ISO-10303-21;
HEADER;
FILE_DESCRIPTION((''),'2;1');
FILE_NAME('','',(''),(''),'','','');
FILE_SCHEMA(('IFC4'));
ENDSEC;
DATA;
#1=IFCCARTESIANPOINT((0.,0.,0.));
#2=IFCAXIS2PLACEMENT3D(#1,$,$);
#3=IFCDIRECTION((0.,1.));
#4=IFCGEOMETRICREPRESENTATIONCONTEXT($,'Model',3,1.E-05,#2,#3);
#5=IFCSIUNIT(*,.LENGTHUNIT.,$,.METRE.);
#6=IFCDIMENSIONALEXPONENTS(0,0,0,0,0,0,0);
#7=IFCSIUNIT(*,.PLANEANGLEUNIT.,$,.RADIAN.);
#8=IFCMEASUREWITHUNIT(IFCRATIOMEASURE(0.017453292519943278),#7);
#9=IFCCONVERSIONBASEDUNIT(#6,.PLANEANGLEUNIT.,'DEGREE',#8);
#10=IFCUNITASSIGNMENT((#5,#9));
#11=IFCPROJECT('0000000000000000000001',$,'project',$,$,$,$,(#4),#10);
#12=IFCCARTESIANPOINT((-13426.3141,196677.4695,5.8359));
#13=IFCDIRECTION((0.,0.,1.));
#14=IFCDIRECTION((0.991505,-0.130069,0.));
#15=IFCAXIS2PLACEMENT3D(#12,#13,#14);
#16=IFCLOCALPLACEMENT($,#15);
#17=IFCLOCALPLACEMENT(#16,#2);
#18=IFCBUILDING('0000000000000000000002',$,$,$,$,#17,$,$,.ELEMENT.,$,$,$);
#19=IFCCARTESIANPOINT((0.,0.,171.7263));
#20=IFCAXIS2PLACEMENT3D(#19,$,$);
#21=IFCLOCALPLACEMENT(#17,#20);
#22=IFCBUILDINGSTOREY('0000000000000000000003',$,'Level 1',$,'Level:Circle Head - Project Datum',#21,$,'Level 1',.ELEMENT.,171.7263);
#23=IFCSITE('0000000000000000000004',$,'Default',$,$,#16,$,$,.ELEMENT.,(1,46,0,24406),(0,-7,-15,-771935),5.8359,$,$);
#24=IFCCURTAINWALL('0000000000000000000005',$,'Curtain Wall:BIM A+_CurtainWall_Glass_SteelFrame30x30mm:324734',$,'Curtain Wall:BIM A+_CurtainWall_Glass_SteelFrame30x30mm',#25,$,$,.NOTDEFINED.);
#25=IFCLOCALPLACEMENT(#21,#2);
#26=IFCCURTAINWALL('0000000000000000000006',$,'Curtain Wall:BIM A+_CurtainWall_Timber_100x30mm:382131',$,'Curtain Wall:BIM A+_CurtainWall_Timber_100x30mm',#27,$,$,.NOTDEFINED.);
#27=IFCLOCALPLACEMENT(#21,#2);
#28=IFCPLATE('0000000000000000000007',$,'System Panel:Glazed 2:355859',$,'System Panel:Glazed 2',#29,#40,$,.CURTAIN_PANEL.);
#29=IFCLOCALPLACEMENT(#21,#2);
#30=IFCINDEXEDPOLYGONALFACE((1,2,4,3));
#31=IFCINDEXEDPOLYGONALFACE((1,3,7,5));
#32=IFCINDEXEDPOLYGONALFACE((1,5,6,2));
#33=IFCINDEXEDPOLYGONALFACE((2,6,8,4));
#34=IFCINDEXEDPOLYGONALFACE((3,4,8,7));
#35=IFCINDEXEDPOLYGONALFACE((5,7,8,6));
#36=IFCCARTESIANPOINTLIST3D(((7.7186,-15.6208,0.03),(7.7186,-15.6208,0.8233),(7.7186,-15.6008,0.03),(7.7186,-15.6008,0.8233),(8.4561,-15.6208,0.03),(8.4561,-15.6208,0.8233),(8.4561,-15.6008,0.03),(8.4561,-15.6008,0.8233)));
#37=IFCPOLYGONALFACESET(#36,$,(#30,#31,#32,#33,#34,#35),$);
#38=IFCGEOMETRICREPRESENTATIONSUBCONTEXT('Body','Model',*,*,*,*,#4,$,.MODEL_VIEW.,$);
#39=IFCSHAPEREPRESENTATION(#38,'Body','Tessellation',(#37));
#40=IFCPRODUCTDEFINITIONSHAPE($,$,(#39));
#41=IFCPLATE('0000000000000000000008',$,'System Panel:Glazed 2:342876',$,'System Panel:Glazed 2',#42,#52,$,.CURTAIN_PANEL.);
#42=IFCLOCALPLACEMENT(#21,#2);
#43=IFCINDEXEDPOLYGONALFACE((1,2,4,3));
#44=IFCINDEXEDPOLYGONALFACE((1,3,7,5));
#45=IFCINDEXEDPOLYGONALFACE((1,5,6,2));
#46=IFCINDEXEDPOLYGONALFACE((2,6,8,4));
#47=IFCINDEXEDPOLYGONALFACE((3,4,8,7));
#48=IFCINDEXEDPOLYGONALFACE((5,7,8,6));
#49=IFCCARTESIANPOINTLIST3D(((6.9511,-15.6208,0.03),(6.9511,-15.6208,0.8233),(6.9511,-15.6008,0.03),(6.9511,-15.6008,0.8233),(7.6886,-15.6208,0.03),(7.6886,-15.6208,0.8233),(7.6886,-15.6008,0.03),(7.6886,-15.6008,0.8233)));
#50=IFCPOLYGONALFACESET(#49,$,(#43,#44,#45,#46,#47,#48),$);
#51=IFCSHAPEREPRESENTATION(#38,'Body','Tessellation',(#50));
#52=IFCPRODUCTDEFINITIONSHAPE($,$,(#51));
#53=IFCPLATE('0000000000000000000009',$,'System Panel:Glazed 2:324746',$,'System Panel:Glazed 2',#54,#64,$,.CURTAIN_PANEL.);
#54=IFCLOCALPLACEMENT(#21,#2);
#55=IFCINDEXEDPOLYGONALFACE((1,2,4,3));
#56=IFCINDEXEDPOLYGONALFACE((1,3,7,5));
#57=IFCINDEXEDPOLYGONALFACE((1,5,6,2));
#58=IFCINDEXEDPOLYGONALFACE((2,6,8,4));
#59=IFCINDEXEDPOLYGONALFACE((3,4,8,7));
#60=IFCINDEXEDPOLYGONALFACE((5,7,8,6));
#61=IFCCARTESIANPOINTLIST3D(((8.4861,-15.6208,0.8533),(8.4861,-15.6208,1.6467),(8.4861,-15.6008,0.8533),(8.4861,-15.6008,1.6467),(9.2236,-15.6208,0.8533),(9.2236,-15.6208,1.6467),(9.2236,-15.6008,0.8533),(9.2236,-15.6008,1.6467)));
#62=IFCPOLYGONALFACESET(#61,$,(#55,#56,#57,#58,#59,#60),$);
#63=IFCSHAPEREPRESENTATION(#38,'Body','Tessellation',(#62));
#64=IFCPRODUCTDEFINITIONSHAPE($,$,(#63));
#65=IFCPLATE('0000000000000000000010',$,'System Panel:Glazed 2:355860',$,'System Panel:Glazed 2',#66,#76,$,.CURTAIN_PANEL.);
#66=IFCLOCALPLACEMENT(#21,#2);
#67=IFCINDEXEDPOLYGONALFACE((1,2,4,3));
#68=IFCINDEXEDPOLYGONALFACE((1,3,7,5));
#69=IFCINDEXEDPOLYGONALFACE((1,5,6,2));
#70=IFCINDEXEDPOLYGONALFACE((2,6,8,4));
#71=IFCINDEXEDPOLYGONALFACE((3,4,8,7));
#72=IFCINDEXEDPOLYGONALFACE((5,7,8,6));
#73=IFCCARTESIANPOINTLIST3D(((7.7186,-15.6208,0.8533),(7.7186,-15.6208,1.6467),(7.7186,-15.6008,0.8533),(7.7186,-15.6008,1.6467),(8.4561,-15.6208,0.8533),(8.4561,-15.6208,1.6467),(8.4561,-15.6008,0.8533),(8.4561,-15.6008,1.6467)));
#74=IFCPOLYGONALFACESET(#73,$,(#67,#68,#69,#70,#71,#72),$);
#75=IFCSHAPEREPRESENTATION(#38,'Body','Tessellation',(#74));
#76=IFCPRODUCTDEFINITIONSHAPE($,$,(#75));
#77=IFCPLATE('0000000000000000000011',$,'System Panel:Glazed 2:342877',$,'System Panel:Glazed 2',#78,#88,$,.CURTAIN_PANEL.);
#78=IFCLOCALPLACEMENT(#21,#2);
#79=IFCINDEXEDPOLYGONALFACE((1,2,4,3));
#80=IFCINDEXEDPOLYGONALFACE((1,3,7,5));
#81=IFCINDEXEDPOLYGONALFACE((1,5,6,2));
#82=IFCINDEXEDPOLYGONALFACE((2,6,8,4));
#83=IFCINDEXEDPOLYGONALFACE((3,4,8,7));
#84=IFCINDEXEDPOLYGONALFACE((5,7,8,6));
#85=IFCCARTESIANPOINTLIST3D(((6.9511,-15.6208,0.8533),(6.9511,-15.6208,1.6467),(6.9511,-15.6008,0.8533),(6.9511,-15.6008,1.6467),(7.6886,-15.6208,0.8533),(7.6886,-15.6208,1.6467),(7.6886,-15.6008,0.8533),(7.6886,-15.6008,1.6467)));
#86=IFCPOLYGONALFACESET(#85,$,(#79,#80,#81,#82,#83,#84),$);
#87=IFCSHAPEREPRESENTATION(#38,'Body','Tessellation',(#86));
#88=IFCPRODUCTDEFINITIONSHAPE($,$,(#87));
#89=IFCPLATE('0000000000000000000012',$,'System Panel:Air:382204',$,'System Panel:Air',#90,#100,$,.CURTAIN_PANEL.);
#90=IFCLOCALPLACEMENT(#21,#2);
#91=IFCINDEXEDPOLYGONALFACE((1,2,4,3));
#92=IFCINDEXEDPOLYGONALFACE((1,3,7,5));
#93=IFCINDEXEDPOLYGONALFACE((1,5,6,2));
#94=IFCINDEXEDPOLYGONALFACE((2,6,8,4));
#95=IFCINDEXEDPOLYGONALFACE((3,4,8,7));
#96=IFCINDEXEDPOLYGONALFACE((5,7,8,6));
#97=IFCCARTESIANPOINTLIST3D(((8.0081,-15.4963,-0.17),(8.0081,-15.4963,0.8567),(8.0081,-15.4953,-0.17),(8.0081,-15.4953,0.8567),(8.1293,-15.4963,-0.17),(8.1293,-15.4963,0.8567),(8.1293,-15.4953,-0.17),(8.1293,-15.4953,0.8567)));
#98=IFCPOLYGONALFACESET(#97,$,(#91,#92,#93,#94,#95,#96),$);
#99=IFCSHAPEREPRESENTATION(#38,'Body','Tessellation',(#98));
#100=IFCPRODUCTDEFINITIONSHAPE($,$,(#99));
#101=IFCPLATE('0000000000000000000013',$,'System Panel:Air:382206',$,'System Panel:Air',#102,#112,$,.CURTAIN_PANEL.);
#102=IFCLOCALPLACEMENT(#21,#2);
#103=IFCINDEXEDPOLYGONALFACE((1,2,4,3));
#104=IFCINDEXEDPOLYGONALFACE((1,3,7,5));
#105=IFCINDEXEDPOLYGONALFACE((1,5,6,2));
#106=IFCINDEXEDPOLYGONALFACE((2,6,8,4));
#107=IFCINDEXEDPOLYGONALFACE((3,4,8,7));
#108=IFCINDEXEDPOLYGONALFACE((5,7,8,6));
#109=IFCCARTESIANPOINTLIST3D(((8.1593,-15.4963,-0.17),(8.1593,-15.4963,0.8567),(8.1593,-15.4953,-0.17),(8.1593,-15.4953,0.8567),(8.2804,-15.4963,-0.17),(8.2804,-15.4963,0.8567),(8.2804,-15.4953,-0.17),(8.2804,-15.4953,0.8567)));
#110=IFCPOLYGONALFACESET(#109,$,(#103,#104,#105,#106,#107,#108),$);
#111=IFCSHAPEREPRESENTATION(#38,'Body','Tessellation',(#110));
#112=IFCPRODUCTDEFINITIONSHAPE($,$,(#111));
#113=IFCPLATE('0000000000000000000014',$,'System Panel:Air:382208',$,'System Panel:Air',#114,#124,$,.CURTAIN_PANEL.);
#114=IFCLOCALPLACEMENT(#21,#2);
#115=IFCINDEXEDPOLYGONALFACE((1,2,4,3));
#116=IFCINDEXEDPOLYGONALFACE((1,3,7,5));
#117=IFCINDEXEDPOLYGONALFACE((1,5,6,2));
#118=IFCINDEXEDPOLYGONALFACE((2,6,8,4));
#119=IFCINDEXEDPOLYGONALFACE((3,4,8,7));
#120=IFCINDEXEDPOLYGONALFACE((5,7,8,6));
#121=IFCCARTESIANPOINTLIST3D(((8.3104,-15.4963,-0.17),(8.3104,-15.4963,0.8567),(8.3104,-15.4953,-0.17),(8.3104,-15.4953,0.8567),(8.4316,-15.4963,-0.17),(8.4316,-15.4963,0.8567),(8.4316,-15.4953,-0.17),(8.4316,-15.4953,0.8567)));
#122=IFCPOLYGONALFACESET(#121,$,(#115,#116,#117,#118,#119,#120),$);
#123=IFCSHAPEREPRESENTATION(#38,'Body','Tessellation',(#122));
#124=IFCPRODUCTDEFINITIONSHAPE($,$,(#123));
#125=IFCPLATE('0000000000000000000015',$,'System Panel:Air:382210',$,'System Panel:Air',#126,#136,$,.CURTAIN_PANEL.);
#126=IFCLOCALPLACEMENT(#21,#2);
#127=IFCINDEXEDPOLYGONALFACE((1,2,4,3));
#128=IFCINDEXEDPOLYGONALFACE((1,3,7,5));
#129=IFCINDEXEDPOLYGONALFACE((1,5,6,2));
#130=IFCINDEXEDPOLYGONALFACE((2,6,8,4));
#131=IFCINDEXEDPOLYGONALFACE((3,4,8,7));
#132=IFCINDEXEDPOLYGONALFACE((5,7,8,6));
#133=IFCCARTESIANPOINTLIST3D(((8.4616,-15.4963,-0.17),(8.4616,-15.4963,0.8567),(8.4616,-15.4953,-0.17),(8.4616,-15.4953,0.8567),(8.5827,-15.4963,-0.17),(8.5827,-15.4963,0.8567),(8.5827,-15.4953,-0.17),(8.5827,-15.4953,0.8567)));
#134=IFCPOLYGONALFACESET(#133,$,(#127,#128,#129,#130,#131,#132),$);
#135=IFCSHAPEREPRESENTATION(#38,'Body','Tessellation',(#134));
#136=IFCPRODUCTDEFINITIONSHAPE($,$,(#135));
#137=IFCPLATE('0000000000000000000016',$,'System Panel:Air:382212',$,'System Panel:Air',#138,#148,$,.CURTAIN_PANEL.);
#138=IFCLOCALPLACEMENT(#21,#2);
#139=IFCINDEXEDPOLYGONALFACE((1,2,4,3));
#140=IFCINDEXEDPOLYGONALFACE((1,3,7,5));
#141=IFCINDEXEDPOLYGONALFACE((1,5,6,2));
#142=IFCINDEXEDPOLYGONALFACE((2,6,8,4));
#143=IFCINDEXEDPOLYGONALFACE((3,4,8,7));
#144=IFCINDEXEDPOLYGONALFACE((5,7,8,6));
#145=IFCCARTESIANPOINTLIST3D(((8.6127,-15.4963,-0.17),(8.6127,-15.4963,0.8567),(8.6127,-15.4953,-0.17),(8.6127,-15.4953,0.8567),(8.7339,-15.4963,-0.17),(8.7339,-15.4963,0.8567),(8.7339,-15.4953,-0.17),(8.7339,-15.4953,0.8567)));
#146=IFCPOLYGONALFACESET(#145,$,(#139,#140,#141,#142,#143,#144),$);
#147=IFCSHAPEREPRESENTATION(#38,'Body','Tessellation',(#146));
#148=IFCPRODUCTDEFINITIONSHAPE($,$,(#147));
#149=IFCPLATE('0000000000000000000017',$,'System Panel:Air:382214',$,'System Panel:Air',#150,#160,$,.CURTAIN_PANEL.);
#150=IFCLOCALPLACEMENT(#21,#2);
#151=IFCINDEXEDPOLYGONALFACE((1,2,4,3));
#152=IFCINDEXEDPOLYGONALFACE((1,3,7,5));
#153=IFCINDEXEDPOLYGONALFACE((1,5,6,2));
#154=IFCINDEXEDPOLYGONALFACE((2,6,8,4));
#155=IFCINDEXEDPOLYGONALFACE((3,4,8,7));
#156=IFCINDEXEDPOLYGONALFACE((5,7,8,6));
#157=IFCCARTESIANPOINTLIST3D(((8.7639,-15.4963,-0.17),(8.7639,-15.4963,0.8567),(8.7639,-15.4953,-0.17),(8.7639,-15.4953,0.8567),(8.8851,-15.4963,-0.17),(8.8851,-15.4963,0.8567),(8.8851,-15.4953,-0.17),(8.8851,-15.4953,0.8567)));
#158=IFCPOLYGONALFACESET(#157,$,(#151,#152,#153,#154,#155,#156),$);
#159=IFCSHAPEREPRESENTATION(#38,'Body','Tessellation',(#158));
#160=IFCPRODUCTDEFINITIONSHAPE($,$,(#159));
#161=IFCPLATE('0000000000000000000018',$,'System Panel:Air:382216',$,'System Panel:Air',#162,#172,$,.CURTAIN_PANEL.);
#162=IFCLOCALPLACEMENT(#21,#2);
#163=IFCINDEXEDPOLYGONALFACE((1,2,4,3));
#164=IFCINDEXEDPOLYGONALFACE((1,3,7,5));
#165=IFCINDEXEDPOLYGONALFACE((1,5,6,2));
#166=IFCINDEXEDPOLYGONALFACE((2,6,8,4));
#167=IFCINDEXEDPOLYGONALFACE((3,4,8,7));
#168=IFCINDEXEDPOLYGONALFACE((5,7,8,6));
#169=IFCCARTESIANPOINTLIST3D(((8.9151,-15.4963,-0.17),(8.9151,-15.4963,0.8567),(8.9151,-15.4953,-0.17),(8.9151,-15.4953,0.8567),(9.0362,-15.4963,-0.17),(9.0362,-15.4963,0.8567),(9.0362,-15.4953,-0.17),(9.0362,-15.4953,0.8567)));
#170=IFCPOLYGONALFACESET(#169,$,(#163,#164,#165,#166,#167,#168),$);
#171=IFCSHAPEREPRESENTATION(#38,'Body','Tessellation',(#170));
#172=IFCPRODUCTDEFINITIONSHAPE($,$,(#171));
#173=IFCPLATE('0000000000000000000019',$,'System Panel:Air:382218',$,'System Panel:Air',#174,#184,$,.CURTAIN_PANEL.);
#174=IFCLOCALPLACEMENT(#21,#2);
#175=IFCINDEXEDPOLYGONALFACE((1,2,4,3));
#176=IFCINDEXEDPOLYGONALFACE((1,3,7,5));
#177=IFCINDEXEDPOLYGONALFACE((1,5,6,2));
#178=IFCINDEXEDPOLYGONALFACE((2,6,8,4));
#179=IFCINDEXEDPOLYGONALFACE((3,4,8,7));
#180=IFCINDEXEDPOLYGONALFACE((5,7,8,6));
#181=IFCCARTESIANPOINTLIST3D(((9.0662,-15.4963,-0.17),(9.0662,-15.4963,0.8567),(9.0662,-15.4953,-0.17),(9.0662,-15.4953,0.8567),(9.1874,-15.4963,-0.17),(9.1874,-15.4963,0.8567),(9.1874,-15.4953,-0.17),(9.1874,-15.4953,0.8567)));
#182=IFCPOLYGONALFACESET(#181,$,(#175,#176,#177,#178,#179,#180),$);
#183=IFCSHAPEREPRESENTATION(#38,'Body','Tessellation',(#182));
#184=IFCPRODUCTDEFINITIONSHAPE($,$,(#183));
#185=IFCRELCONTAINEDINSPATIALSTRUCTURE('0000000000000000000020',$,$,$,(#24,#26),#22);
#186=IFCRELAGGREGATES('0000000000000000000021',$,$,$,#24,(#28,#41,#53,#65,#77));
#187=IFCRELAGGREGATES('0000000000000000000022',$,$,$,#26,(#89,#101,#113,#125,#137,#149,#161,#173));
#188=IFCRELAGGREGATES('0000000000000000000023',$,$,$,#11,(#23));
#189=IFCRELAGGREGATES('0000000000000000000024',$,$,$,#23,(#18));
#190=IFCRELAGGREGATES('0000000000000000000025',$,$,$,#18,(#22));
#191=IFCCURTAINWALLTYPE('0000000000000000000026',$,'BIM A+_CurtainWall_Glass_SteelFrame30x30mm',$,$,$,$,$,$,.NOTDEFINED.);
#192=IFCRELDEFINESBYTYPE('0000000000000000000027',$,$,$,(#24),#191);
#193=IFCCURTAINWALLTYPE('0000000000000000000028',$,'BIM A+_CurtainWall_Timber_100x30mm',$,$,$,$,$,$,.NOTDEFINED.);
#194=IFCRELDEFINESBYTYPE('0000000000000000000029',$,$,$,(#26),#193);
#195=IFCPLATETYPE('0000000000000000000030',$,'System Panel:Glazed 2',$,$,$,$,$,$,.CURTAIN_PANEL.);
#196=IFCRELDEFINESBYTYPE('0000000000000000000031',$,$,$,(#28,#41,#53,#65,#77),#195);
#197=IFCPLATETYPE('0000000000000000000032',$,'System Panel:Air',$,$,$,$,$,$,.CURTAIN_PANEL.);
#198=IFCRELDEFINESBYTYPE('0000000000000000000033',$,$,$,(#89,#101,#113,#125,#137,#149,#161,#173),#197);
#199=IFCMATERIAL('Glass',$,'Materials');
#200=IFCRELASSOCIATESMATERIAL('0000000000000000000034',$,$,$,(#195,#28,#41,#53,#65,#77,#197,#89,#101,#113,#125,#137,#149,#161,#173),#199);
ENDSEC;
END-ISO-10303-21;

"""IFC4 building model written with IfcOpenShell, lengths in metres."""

from ifc_helpers import new_model, entity, si_unit, converted_unit, direction, frame, origin, place, context, subcontext, project, spatial, indexed_curve, outline, extrude, source, transform, mapped, material, type_object, type_shapes, element, aggregate, save


model = new_model("IFC4")

# Units and contexts
model_context = context("Model", 3, precision=1e-05, world=origin(), true_north=direction((0.0, 1.0)))
body_context = subcontext(model_context, "Body", "Model", "MODEL_VIEW")
ifc_project = project(units=[si_unit("LENGTHUNIT", "METRE"), converted_unit("PLANEANGLEUNIT", "DEGREE", entity("IfcRatioMeasure", 0.017453292519943278), si_unit("PLANEANGLEUNIT", "RADIAN"), dimensions=[0, 0, 0, 0, 0, 0, 0])], contexts=[model_context])

# Site, building, storey
site_placement = place(None, frame((-13426.3141, 196677.4695, 5.8359), z_axis=(0.0, 0.0, 1.0), x_axis=(0.991505, -0.130069, 0.0)))
site = spatial("IfcSite", under=ifc_project, at=site_placement, Name="Default", CompositionType="ELEMENT", RefLatitude=(1, 46, 0, 24406), RefLongitude=(0, -7, -15, -771935), RefElevation=5.8359)
building_placement = place(site_placement, origin())
building = spatial("IfcBuilding", under=site, at=building_placement, CompositionType="ELEMENT")
storey_placement = place(building_placement, frame((0.0, 0.0, 171.7263)))
storey = spatial("IfcBuildingStorey", under=building, at=storey_placement, Name="Level 1", ObjectType="Level:Circle Head - Project Datum", LongName="Level 1", CompositionType="ELEMENT", Elevation=171.7263)

# Curtain walls
curtain_wall_type_1 = type_object("IfcCurtainWallType", Name="BIM A+_CurtainWall_Glass_SteelFrame30x30mm", PredefinedType="NOTDEFINED")
curtain_wall_1_placement = place(storey_placement, frame((0.0, 0.0, -171.7263)))
curtain_wall_1 = element("IfcCurtainWall", 1, at=curtain_wall_1_placement, inside=storey, type_object=curtain_wall_type_1, Name="Curtain Wall:BIM A+_CurtainWall_Glass_SteelFrame30x30mm:324734", ObjectType="Curtain Wall:BIM A+_CurtainWall_Glass_SteelFrame30x30mm", PredefinedType="NOTDEFINED")
curtain_wall_type_2 = type_object("IfcCurtainWallType", Name="BIM A+_CurtainWall_Timber_100x30mm", PredefinedType="NOTDEFINED")
curtain_wall_2_placement = place(storey_placement, frame((0.0, 0.0, -171.7263)))
curtain_wall_2 = element("IfcCurtainWall", 2, at=curtain_wall_2_placement, inside=storey, type_object=curtain_wall_type_2, Name="Curtain Wall:BIM A+_CurtainWall_Timber_100x30mm:382131", ObjectType="Curtain Wall:BIM A+_CurtainWall_Timber_100x30mm", PredefinedType="NOTDEFINED")

# Plates
ifc_material_1 = material(Name="Glass", Category="Materials")
plate_type_1 = type_object("IfcPlateType", Name="System Panel:Glazed 2", PredefinedType="CURTAIN_PANEL", material=ifc_material_1)
shared_shape_1 = source(origin(), body_context, "Body", "SweptSolid", [
    extrude(outline(indexed_curve([(-0.01, -0.3688), (0.01, -0.3688), (0.01, 0.3688), (-0.01, 0.3688), (-0.01, -0.3688)], self_intersect=False)), frame((0.0, 0.0, 0.0), z_axis=(0.0, 0.0, 1.0), x_axis=(0.0, 1.0, 0.0)), (0.0, 0.0, 1.0), 0.7933),
])
type_shapes(plate_type_1, [shared_shape_1])
plate_1_placement = place(curtain_wall_1_placement, frame((8.0873, -15.6108, 171.7563), z_axis=(0.0, 0.0, 1.0), x_axis=(-1.0, 0.0, 0.0)))
plate_1 = element("IfcPlate", 3, at=plate_1_placement, type_object=plate_type_1, material=ifc_material_1, Name="System Panel:Glazed 2:355859", ObjectType="System Panel:Glazed 2", PredefinedType="CURTAIN_PANEL", context=body_context, shape_type="MappedRepresentation", body=[
    mapped(shared_shape_1, transform((0.0, 0.0, 0.0), scale=1.0)),
])
plate_2_placement = place(curtain_wall_1_placement, frame((7.3198, -15.6108, 171.7563), z_axis=(0.0, 0.0, 1.0), x_axis=(-1.0, 0.0, 0.0)))
plate_2 = element("IfcPlate", 4, at=plate_2_placement, type_object=plate_type_1, material=ifc_material_1, Name="System Panel:Glazed 2:342876", ObjectType="System Panel:Glazed 2", PredefinedType="CURTAIN_PANEL", context=body_context, shape_type="MappedRepresentation", body=[
    mapped(shared_shape_1, transform((0.0, 0.0, 0.0), scale=1.0)),
])
plate_3_placement = place(curtain_wall_1_placement, frame((8.8548, -15.6108, 172.5796), z_axis=(0.0, 0.0, 1.0), x_axis=(-1.0, 0.0, 0.0)))
plate_3 = element("IfcPlate", 5, at=plate_3_placement, type_object=plate_type_1, material=ifc_material_1, Name="System Panel:Glazed 2:324746", ObjectType="System Panel:Glazed 2", PredefinedType="CURTAIN_PANEL", context=body_context, shape_type="MappedRepresentation", body=[
    mapped(shared_shape_1, transform((0.0, 0.0, 0.0), scale=1.0)),
])
plate_4_placement = place(curtain_wall_1_placement, frame((8.0873, -15.6108, 172.5796), z_axis=(0.0, 0.0, 1.0), x_axis=(-1.0, 0.0, 0.0)))
plate_4 = element("IfcPlate", 6, at=plate_4_placement, type_object=plate_type_1, material=ifc_material_1, Name="System Panel:Glazed 2:355860", ObjectType="System Panel:Glazed 2", PredefinedType="CURTAIN_PANEL", context=body_context, shape_type="MappedRepresentation", body=[
    mapped(shared_shape_1, transform((0.0, 0.0, 0.0), scale=1.0)),
])
plate_5_placement = place(curtain_wall_1_placement, frame((7.3198, -15.6108, 172.5796), z_axis=(0.0, 0.0, 1.0), x_axis=(-1.0, 0.0, 0.0)))
plate_5 = element("IfcPlate", 7, at=plate_5_placement, type_object=plate_type_1, material=ifc_material_1, Name="System Panel:Glazed 2:342877", ObjectType="System Panel:Glazed 2", PredefinedType="CURTAIN_PANEL", context=body_context, shape_type="MappedRepresentation", body=[
    mapped(shared_shape_1, transform((0.0, 0.0, 0.0), scale=1.0)),
])
aggregate(curtain_wall_1, [plate_1, plate_2, plate_3, plate_4, plate_5])
plate_type_2 = type_object("IfcPlateType", Name="System Panel:Air", PredefinedType="CURTAIN_PANEL", material=ifc_material_1)
shared_shape_2 = source(origin(), body_context, "Body", "SweptSolid", [
    extrude(outline(indexed_curve([(-0.0005, -0.0606), (0.0005, -0.0606), (0.0005, 0.0606), (-0.0005, 0.0606), (-0.0005, -0.0606)], self_intersect=False)), frame((0.0, 0.0, 0.0), z_axis=(0.0, 0.0, 1.0), x_axis=(0.0, 1.0, 0.0)), (0.0, 0.0, 1.0), 1.0267),
])
type_shapes(plate_type_2, [shared_shape_2])
plate_6_placement = place(curtain_wall_2_placement, frame((8.0687, -15.4958, 171.5563)))
plate_6 = element("IfcPlate", 8, at=plate_6_placement, type_object=plate_type_2, material=ifc_material_1, Name="System Panel:Air:382204", ObjectType="System Panel:Air", PredefinedType="CURTAIN_PANEL", context=body_context, shape_type="MappedRepresentation", body=[
    mapped(shared_shape_2, transform((0.0, 0.0, 0.0), scale=1.0)),
])
plate_7_placement = place(curtain_wall_2_placement, frame((8.2198, -15.4958, 171.5563)))
plate_7 = element("IfcPlate", 9, at=plate_7_placement, type_object=plate_type_2, material=ifc_material_1, Name="System Panel:Air:382206", ObjectType="System Panel:Air", PredefinedType="CURTAIN_PANEL", context=body_context, shape_type="MappedRepresentation", body=[
    mapped(shared_shape_2, transform((0.0, 0.0, 0.0), scale=1.0)),
])
plate_8_placement = place(curtain_wall_2_placement, frame((8.371, -15.4958, 171.5563)))
plate_8 = element("IfcPlate", 10, at=plate_8_placement, type_object=plate_type_2, material=ifc_material_1, Name="System Panel:Air:382208", ObjectType="System Panel:Air", PredefinedType="CURTAIN_PANEL", context=body_context, shape_type="MappedRepresentation", body=[
    mapped(shared_shape_2, transform((0.0, 0.0, 0.0), scale=1.0)),
])
plate_9_placement = place(curtain_wall_2_placement, frame((8.5222, -15.4958, 171.5563)))
plate_9 = element("IfcPlate", 11, at=plate_9_placement, type_object=plate_type_2, material=ifc_material_1, Name="System Panel:Air:382210", ObjectType="System Panel:Air", PredefinedType="CURTAIN_PANEL", context=body_context, shape_type="MappedRepresentation", body=[
    mapped(shared_shape_2, transform((0.0, 0.0, 0.0), scale=1.0)),
])
plate_10_placement = place(curtain_wall_2_placement, frame((8.6733, -15.4958, 171.5563)))
plate_10 = element("IfcPlate", 12, at=plate_10_placement, type_object=plate_type_2, material=ifc_material_1, Name="System Panel:Air:382212", ObjectType="System Panel:Air", PredefinedType="CURTAIN_PANEL", context=body_context, shape_type="MappedRepresentation", body=[
    mapped(shared_shape_2, transform((0.0, 0.0, 0.0), scale=1.0)),
])
plate_11_placement = place(curtain_wall_2_placement, frame((8.8245, -15.4958, 171.5563)))
plate_11 = element("IfcPlate", 13, at=plate_11_placement, type_object=plate_type_2, material=ifc_material_1, Name="System Panel:Air:382214", ObjectType="System Panel:Air", PredefinedType="CURTAIN_PANEL", context=body_context, shape_type="MappedRepresentation", body=[
    mapped(shared_shape_2, transform((0.0, 0.0, 0.0), scale=1.0)),
])
plate_12_placement = place(curtain_wall_2_placement, frame((8.9757, -15.4958, 171.5563)))
plate_12 = element("IfcPlate", 14, at=plate_12_placement, type_object=plate_type_2, material=ifc_material_1, Name="System Panel:Air:382216", ObjectType="System Panel:Air", PredefinedType="CURTAIN_PANEL", context=body_context, shape_type="MappedRepresentation", body=[
    mapped(shared_shape_2, transform((0.0, 0.0, 0.0), scale=1.0)),
])
plate_13_placement = place(curtain_wall_2_placement, frame((9.1268, -15.4958, 171.5563)))
plate_13 = element("IfcPlate", 15, at=plate_13_placement, type_object=plate_type_2, material=ifc_material_1, Name="System Panel:Air:382218", ObjectType="System Panel:Air", PredefinedType="CURTAIN_PANEL", context=body_context, shape_type="MappedRepresentation", body=[
    mapped(shared_shape_2, transform((0.0, 0.0, 0.0), scale=1.0)),
])
aggregate(curtain_wall_2, [plate_6, plate_7, plate_8, plate_9, plate_10, plate_11, plate_12, plate_13])

save(model, "model.ifc")
